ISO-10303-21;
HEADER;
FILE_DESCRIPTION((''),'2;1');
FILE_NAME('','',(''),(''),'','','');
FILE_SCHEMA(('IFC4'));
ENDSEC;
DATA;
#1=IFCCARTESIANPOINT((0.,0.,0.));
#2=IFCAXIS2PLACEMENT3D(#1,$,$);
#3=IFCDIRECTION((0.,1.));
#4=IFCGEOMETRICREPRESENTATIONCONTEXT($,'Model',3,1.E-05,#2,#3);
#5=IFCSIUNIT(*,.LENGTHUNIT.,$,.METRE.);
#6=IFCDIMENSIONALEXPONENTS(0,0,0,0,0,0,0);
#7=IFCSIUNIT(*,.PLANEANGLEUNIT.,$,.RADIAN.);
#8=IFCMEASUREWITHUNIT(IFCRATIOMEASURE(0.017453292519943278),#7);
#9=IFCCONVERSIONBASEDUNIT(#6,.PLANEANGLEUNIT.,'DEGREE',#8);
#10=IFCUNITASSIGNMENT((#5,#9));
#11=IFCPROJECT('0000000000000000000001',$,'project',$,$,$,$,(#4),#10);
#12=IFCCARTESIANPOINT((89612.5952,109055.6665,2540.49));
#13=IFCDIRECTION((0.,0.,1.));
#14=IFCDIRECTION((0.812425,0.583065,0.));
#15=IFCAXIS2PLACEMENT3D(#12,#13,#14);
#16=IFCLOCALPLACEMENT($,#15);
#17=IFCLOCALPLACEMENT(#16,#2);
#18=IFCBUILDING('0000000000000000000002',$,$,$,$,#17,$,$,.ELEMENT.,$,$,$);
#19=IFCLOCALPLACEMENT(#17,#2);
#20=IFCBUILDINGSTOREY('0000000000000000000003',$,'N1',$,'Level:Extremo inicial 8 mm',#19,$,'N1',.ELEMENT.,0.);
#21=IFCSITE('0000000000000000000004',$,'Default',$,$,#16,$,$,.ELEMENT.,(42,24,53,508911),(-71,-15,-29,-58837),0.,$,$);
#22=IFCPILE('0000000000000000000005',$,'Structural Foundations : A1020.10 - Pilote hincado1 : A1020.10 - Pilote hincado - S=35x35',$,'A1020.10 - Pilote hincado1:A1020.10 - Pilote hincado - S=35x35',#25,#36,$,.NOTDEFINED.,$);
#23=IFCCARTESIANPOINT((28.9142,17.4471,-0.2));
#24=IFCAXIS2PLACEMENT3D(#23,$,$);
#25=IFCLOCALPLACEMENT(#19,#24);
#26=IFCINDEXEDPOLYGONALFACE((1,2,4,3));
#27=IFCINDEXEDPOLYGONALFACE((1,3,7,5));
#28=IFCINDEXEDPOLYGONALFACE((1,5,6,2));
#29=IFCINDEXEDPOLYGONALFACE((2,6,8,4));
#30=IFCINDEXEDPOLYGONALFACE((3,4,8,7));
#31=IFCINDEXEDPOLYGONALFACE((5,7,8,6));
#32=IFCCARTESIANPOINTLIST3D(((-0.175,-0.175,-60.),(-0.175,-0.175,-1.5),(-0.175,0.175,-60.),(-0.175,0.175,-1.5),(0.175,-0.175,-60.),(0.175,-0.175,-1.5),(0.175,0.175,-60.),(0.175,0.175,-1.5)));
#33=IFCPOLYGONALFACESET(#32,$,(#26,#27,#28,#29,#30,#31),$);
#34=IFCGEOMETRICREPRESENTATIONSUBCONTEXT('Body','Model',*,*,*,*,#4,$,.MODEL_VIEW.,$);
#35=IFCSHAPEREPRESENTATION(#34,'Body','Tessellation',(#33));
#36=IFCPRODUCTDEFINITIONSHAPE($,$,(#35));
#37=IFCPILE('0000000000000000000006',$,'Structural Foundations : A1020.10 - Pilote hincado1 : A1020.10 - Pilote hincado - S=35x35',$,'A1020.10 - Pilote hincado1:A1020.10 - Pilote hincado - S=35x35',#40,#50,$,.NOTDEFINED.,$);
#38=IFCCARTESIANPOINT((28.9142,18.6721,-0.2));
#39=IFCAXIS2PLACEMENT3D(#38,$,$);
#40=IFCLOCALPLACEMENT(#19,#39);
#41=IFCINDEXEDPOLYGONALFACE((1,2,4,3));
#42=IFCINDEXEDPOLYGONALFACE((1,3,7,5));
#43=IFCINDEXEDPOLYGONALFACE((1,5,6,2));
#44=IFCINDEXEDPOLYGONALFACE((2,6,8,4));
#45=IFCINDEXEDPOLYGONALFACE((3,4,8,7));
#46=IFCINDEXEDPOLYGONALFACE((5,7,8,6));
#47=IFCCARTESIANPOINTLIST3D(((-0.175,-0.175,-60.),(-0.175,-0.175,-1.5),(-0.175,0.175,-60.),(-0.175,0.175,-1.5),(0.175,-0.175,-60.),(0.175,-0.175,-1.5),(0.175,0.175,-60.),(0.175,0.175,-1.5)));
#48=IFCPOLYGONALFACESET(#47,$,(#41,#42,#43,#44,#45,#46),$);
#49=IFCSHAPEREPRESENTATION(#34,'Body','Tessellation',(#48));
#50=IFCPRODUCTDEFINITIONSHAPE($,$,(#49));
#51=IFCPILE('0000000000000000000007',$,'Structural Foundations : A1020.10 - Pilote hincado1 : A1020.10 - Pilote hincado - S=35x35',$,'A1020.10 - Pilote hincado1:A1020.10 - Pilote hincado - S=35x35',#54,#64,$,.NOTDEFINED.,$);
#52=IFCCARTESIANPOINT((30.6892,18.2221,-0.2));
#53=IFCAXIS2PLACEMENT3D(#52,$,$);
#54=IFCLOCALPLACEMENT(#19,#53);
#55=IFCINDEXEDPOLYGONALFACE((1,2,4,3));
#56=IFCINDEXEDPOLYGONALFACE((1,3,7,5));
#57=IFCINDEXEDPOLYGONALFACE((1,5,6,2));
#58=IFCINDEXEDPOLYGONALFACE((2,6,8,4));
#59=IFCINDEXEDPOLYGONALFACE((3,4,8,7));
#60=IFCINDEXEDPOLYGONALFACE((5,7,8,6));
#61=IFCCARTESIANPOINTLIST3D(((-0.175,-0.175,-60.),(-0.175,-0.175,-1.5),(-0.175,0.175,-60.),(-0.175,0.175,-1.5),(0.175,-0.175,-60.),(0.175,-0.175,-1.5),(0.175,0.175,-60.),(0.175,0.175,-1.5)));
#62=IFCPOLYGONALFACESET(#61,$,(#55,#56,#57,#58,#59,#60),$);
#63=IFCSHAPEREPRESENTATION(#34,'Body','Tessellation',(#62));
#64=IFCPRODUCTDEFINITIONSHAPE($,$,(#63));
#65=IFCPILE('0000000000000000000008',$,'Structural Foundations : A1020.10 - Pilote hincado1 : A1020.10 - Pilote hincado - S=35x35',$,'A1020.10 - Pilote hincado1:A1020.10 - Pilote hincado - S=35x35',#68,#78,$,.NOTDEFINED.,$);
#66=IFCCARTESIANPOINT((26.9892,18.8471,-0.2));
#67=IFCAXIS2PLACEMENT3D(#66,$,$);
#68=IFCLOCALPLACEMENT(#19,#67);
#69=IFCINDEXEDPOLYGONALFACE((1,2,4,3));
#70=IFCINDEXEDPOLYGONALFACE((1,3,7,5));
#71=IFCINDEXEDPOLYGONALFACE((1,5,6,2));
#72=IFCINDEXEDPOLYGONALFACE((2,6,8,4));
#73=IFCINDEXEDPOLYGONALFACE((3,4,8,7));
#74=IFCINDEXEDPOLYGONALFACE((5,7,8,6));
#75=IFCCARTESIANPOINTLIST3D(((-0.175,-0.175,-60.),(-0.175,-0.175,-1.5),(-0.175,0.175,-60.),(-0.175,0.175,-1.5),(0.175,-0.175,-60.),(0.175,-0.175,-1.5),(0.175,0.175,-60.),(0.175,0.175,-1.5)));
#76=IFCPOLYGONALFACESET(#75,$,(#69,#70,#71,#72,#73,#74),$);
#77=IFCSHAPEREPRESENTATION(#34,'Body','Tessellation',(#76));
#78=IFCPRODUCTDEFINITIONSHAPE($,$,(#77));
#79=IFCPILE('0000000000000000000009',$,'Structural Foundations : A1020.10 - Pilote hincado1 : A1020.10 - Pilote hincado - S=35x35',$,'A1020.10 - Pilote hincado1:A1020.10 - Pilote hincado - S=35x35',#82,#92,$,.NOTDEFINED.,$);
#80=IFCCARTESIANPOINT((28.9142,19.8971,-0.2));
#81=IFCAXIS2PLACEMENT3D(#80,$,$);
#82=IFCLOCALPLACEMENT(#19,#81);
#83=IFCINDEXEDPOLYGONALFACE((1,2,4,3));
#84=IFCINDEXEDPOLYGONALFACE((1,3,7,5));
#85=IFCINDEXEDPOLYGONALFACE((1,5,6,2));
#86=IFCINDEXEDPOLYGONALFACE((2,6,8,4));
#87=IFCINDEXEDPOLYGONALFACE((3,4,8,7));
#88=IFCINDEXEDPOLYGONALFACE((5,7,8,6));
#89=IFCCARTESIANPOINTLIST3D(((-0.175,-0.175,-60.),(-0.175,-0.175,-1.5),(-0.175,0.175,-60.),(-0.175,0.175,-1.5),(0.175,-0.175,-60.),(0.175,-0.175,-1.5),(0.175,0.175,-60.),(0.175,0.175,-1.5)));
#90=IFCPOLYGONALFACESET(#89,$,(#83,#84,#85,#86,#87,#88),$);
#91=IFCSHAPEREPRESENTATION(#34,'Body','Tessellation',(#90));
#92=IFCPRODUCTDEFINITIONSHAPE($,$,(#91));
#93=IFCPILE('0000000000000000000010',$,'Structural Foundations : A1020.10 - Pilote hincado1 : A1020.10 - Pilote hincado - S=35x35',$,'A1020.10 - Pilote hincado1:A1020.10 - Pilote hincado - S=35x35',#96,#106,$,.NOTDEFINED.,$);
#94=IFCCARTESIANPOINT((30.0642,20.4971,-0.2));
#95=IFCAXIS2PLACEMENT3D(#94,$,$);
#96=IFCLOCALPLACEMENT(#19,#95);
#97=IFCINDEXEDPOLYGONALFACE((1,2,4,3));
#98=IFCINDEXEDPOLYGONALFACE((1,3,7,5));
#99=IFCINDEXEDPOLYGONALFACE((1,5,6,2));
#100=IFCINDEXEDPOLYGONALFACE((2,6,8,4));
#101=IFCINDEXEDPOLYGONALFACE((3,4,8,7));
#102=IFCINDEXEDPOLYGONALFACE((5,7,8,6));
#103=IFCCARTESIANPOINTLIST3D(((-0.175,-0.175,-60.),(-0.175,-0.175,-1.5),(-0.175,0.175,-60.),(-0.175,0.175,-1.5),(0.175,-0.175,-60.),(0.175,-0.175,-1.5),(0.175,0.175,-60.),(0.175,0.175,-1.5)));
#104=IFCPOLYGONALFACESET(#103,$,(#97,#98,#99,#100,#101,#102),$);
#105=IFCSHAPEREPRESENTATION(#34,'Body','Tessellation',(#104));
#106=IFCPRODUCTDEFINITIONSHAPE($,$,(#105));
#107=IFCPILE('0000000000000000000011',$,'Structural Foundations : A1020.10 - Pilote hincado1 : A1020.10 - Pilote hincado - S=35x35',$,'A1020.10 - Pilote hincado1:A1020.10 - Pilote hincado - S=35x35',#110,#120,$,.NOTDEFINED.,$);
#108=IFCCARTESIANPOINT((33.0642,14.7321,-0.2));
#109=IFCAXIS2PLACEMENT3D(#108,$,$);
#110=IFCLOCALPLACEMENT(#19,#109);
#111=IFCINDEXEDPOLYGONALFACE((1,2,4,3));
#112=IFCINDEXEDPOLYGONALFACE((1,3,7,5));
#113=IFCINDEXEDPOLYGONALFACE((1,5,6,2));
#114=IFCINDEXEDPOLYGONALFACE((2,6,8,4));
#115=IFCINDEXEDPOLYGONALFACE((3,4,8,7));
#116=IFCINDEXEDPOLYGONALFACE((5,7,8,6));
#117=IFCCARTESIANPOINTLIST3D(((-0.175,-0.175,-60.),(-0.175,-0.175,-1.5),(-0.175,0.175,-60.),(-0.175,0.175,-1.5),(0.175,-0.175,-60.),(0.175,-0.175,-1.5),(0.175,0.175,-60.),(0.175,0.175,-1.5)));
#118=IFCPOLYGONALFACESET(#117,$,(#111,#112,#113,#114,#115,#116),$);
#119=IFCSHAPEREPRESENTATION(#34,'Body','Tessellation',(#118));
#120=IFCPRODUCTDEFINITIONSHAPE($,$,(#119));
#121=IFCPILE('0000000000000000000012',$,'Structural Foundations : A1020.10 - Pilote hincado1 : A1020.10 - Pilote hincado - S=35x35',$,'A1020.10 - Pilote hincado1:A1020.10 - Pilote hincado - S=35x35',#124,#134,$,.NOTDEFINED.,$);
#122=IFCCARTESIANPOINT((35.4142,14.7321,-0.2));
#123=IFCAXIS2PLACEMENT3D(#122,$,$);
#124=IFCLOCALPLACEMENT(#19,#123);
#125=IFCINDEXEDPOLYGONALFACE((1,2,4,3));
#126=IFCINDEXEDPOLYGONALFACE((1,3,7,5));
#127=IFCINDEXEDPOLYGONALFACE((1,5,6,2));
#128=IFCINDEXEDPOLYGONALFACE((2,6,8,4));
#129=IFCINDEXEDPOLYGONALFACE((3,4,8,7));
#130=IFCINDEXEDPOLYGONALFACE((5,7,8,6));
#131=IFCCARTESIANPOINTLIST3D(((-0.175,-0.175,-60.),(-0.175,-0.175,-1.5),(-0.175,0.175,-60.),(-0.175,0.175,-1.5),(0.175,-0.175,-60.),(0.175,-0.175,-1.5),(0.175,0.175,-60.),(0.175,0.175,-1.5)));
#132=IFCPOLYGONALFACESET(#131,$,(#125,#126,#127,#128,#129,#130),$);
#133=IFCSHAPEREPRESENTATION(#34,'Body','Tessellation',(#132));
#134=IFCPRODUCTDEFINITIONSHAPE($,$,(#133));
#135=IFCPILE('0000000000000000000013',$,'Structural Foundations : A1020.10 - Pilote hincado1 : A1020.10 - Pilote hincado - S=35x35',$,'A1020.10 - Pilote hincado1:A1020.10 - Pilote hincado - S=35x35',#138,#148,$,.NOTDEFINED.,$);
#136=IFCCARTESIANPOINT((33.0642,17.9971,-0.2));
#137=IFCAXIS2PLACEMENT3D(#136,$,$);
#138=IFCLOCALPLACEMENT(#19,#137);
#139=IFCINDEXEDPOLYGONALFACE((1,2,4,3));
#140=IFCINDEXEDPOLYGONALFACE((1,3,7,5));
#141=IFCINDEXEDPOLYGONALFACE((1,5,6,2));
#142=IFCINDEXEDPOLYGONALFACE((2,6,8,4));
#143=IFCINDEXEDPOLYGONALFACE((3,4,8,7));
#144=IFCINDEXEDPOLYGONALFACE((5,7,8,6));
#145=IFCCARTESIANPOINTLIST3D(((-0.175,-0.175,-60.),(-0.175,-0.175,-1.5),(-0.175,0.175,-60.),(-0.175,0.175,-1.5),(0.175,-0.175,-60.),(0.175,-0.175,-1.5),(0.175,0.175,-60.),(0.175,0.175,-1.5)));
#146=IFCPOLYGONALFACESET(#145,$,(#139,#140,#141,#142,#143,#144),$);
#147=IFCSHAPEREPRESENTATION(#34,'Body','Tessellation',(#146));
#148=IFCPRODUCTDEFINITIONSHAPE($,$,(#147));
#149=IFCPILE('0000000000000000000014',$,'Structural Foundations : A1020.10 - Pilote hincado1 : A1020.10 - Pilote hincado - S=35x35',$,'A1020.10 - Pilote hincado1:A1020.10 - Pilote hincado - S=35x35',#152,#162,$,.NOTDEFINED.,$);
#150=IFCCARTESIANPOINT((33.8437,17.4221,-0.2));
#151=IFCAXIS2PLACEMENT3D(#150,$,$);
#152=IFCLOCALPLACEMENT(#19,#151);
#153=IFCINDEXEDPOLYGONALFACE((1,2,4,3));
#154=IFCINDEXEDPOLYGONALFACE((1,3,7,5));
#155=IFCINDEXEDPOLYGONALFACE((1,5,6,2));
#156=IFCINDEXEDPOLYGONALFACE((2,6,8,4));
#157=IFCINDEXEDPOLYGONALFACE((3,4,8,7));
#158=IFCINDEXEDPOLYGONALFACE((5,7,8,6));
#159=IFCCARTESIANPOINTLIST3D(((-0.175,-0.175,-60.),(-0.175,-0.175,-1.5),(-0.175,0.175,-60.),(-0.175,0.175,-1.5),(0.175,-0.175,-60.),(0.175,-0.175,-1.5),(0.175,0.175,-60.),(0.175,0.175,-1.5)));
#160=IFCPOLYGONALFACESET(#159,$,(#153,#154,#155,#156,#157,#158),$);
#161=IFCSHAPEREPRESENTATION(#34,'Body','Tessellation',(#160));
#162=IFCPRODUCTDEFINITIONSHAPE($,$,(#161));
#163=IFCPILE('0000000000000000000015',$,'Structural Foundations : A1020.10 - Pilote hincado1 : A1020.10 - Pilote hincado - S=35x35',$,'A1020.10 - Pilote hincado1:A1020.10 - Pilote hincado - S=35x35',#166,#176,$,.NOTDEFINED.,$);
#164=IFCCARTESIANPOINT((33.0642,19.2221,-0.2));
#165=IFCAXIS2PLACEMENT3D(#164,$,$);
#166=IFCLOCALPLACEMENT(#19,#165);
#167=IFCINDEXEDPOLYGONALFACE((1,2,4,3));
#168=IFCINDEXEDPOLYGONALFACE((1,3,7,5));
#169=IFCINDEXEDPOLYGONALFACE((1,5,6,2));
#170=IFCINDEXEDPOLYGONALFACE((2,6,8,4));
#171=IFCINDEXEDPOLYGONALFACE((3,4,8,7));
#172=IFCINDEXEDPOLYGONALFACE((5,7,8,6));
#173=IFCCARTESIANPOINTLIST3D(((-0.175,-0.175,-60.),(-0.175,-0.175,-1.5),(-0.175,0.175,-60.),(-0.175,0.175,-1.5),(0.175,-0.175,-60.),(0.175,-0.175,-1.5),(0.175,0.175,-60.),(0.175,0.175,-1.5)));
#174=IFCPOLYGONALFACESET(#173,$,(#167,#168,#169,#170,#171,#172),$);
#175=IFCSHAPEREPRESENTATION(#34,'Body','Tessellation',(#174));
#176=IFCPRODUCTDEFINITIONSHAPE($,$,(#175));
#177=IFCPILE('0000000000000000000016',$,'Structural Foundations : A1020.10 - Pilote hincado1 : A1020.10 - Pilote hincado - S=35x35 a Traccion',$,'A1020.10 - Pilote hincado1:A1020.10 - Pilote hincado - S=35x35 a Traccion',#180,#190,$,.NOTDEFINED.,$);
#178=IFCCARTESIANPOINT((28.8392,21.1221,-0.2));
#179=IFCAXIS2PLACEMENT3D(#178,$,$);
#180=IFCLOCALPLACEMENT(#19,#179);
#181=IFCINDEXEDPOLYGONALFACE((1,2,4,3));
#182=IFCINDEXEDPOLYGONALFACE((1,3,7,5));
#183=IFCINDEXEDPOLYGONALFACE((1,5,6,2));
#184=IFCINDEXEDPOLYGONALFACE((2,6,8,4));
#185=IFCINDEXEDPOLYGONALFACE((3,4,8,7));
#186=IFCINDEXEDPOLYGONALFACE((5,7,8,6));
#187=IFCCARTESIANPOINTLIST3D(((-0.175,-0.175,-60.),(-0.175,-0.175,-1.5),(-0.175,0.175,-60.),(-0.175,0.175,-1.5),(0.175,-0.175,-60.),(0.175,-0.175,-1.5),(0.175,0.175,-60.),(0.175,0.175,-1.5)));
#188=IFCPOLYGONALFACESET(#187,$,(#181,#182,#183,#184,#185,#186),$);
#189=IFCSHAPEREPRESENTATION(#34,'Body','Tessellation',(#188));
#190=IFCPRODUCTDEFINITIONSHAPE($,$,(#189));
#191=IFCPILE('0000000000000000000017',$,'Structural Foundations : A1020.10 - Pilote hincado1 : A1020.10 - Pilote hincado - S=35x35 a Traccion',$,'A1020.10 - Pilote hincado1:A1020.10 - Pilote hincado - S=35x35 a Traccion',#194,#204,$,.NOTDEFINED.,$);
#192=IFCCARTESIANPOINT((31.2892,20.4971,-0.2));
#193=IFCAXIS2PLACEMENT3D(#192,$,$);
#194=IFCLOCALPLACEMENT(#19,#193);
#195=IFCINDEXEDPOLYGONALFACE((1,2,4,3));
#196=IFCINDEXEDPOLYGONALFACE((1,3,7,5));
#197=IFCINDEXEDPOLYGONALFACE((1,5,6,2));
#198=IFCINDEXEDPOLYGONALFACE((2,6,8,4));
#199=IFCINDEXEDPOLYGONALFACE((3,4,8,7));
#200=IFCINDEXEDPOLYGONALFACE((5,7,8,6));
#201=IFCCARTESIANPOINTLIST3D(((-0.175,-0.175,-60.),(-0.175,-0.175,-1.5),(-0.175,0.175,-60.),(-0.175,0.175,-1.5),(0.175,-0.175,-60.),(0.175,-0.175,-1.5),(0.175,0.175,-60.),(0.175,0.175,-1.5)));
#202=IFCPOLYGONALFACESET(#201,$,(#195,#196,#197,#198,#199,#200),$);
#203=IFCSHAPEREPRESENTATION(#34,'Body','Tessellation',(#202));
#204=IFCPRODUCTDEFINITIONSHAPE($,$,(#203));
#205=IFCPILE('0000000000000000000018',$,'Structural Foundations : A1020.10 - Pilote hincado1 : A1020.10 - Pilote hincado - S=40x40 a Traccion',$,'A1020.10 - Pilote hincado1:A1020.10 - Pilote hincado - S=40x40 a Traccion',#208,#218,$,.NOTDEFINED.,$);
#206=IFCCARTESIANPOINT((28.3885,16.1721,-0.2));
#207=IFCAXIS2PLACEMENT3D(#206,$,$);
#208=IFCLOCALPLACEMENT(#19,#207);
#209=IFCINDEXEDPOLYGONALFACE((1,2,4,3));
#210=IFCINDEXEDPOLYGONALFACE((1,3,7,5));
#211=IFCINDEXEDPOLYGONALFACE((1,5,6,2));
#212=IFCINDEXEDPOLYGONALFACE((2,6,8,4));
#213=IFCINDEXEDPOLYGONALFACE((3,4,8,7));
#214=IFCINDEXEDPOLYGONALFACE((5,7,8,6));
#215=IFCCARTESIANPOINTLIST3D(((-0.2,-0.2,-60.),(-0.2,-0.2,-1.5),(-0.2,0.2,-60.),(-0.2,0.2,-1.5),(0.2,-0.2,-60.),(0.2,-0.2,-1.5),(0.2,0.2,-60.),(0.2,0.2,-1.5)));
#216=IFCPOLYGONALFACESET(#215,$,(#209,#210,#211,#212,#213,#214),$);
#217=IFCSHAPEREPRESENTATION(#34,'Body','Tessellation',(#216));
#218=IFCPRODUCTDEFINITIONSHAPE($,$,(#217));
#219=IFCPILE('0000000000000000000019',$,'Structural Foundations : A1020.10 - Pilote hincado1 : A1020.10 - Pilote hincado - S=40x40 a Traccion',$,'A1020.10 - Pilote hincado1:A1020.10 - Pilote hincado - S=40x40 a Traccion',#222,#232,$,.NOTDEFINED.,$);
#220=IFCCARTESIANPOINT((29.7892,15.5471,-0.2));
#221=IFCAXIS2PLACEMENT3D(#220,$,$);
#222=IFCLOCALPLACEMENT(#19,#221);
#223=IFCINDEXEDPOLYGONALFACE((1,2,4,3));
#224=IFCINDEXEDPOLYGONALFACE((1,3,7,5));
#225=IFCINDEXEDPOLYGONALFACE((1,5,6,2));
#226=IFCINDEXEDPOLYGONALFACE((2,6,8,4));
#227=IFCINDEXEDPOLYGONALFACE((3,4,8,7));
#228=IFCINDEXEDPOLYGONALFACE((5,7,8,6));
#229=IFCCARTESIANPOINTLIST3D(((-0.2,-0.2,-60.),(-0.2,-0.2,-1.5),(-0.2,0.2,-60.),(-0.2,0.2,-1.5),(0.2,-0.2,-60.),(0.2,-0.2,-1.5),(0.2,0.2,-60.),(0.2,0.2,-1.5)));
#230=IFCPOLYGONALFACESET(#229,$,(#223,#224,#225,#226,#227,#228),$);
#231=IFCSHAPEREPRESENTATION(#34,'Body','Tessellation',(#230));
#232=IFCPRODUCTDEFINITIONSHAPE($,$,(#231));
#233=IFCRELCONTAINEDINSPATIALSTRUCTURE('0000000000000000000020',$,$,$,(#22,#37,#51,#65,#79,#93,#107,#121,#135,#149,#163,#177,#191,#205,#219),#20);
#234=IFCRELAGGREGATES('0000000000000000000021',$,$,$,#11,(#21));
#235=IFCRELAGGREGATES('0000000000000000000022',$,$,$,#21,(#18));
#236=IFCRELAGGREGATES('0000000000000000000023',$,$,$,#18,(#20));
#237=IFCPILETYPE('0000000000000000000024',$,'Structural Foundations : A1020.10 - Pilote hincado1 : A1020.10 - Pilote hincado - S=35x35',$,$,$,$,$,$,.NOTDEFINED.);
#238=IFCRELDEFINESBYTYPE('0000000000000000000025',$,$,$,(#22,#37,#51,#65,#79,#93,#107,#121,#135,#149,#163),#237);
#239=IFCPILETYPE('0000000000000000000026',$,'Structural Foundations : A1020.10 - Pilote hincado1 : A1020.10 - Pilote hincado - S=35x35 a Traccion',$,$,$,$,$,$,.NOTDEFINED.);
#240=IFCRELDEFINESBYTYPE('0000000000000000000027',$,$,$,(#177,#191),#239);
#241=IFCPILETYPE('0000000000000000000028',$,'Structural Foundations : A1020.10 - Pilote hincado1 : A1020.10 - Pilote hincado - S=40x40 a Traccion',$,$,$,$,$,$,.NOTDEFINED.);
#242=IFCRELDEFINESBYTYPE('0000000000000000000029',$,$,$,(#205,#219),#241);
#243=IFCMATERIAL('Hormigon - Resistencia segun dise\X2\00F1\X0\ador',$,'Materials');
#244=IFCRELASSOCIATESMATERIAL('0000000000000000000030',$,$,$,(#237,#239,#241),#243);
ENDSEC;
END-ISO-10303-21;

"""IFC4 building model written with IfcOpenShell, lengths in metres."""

from ifc_helpers import new_model, entity, si_unit, converted_unit, direction, frame, origin, origin_2d_with_axis, place, context, subcontext, project, spatial, polyline, segment, composite_curve, rectangle, outline, extrude, source, transform, mapped, material, material_profile, profile_set, type_object, type_shapes, element, save


model = new_model("IFC4")

# Units and contexts
model_context = context("Model", 3, precision=1e-05, world=origin(), true_north=direction((0.0, 1.0)))
body_context = subcontext(model_context, "Body", "Model", "MODEL_VIEW")
ifc_project = project(units=[si_unit("LENGTHUNIT", "METRE"), converted_unit("PLANEANGLEUNIT", "DEGREE", entity("IfcRatioMeasure", 0.017453292519943278), si_unit("PLANEANGLEUNIT", "RADIAN"), dimensions=[0, 0, 0, 0, 0, 0, 0])], contexts=[model_context])

# Site, building, storey
site_placement = place(None, frame((89612.5952, 109055.6665, 2540.49), z_axis=(0.0, 0.0, 1.0), x_axis=(0.812425, 0.583065, 0.0)))
site = spatial("IfcSite", under=ifc_project, at=site_placement, Name="Default", CompositionType="ELEMENT", RefLatitude=(42, 24, 53, 508911), RefLongitude=(-71, -15, -29, -58837), RefElevation=0.0)
building_placement = place(site_placement, origin())
building = spatial("IfcBuilding", under=site, at=building_placement, CompositionType="ELEMENT")
storey_placement = place(building_placement, origin())
storey = spatial("IfcBuildingStorey", under=building, at=storey_placement, Name="N1", ObjectType="Level:Extremo inicial 8 mm", LongName="N1", CompositionType="ELEMENT", Elevation=0.0)

# Piles
ifc_material_1 = material(Name="Hormigon - Resistencia segun diseñador", Category="Materials")
ifc_material_profile_1 = material_profile(ifc_material_1, outline(composite_curve([segment(polyline([(0.175, 0.175, -60.0), (0.175, -0.175, -60.0)]), True, "CONTINUOUS"), segment(polyline([(0.175, -0.175, -60.0), (-0.175, -0.175, -60.0)]), True, "CONTINUOUS"), segment(polyline([(-0.175, -0.175, -60.0), (-0.175, 0.175, -60.0)]), True, "CONTINUOUS"), segment(polyline([(-0.175, 0.175, -60.0), (0.175, 0.175, -60.0)]), True, "CONTINUOUS")], self_intersect=False), kind="CURVE"), Name="A1020.10 - Pilote hincado - S=35x35")
ifc_profile_set_1 = profile_set([ifc_material_profile_1], Name="A1020.10 - Pilote hincado - S=35x35")
pile_type_1 = type_object("IfcPileType", Name="Structural Foundations : A1020.10 - Pilote hincado1 : A1020.10 - Pilote hincado - S=35x35", PredefinedType="NOTDEFINED", material=ifc_profile_set_1)
shared_shape_1 = source(origin(), body_context, "Body", "SweptSolid", [
    extrude(rectangle(XDim=0.35, YDim=0.35, at=origin_2d_with_axis()), frame((0.0, 0.0, -60.0), z_axis=(0.0, 0.0, 1.0), x_axis=(0.0, -1.0, 0.0)), (0.0, 0.0, 1.0), 58.5),
])
type_shapes(pile_type_1, [shared_shape_1])
for number, where, name in (
    (1, (28.9142, 17.4471, -0.2), "Structural Foundations : A1020.10 - Pilote hincado1 : A1020.10 - Pilote hincado - S=35x35"),
    (2, (28.9142, 18.6721, -0.2), "Structural Foundations : A1020.10 - Pilote hincado1 : A1020.10 - Pilote hincado - S=35x35"),
    (3, (30.6892, 18.2221, -0.2), "Structural Foundations : A1020.10 - Pilote hincado1 : A1020.10 - Pilote hincado - S=35x35"),
    (4, (26.9892, 18.8471, -0.2), "Structural Foundations : A1020.10 - Pilote hincado1 : A1020.10 - Pilote hincado - S=35x35"),
    (5, (28.9142, 19.8971, -0.2), "Structural Foundations : A1020.10 - Pilote hincado1 : A1020.10 - Pilote hincado - S=35x35"),
    (6, (30.0642, 20.4971, -0.2), "Structural Foundations : A1020.10 - Pilote hincado1 : A1020.10 - Pilote hincado - S=35x35"),
    (7, (33.0642, 14.7321, -0.2), "Structural Foundations : A1020.10 - Pilote hincado1 : A1020.10 - Pilote hincado - S=35x35"),
    (8, (35.4142, 14.7321, -0.2), "Structural Foundations : A1020.10 - Pilote hincado1 : A1020.10 - Pilote hincado - S=35x35"),
    (9, (33.0642, 17.9971, -0.2), "Structural Foundations : A1020.10 - Pilote hincado1 : A1020.10 - Pilote hincado - S=35x35"),
    (10, (33.8437, 17.4221, -0.2), "Structural Foundations : A1020.10 - Pilote hincado1 : A1020.10 - Pilote hincado - S=35x35"),
    (11, (33.0642, 19.2221, -0.2), "Structural Foundations : A1020.10 - Pilote hincado1 : A1020.10 - Pilote hincado - S=35x35"),
):
    element("IfcPile", number, at=place(storey_placement, frame(where)), inside=storey, type_object=pile_type_1, Name=name, ObjectType="A1020.10 - Pilote hincado1:A1020.10 - Pilote hincado - S=35x35", PredefinedType="NOTDEFINED", context=body_context, shape_type="MappedRepresentation", body=[
        mapped(shared_shape_1, transform((0.0, 0.0, 0.0), scale=1.0)),
    ])
ifc_material_profile_2 = material_profile(ifc_material_1, outline(composite_curve([segment(polyline([(0.175, 0.175, -60.0), (0.175, -0.175, -60.0)]), True, "CONTINUOUS"), segment(polyline([(0.175, -0.175, -60.0), (-0.175, -0.175, -60.0)]), True, "CONTINUOUS"), segment(polyline([(-0.175, -0.175, -60.0), (-0.175, 0.175, -60.0)]), True, "CONTINUOUS"), segment(polyline([(-0.175, 0.175, -60.0), (0.175, 0.175, -60.0)]), True, "CONTINUOUS")], self_intersect=False), kind="CURVE"), Name="A1020.10 - Pilote hincado - S=35x35 a Traccion")
ifc_profile_set_2 = profile_set([ifc_material_profile_2], Name="A1020.10 - Pilote hincado - S=35x35 a Traccion")
pile_type_2 = type_object("IfcPileType", Name="Structural Foundations : A1020.10 - Pilote hincado1 : A1020.10 - Pilote hincado - S=35x35 a Traccion", PredefinedType="NOTDEFINED", material=ifc_profile_set_2)
shared_shape_2 = source(origin(), body_context, "Body", "SweptSolid", [
    extrude(rectangle(XDim=0.35, YDim=0.35, at=origin_2d_with_axis()), frame((0.0, 0.0, -60.0), z_axis=(0.0, 0.0, 1.0), x_axis=(0.0, -1.0, 0.0)), (0.0, 0.0, 1.0), 58.5),
])
type_shapes(pile_type_2, [shared_shape_2])
for number, where, name in (
    (12, (28.8392, 21.1221, -0.2), "Structural Foundations : A1020.10 - Pilote hincado1 : A1020.10 - Pilote hincado - S=35x35 a Traccion"),
    (13, (31.2892, 20.4971, -0.2), "Structural Foundations : A1020.10 - Pilote hincado1 : A1020.10 - Pilote hincado - S=35x35 a Traccion"),
):
    element("IfcPile", number, at=place(storey_placement, frame(where)), inside=storey, type_object=pile_type_2, Name=name, ObjectType="A1020.10 - Pilote hincado1:A1020.10 - Pilote hincado - S=35x35 a Traccion", PredefinedType="NOTDEFINED", context=body_context, shape_type="MappedRepresentation", body=[
        mapped(shared_shape_2, transform((0.0, 0.0, 0.0), scale=1.0)),
    ])
ifc_material_profile_3 = material_profile(ifc_material_1, outline(composite_curve([segment(polyline([(0.2, 0.2, -60.0), (0.2, -0.2, -60.0)]), True, "CONTINUOUS"), segment(polyline([(0.2, -0.2, -60.0), (-0.2, -0.2, -60.0)]), True, "CONTINUOUS"), segment(polyline([(-0.2, -0.2, -60.0), (-0.2, 0.2, -60.0)]), True, "CONTINUOUS"), segment(polyline([(-0.2, 0.2, -60.0), (0.2, 0.2, -60.0)]), True, "CONTINUOUS")], self_intersect=False), kind="CURVE"), Name="A1020.10 - Pilote hincado - S=40x40 a Traccion")
ifc_profile_set_3 = profile_set([ifc_material_profile_3], Name="A1020.10 - Pilote hincado - S=40x40 a Traccion")
pile_type_3 = type_object("IfcPileType", Name="Structural Foundations : A1020.10 - Pilote hincado1 : A1020.10 - Pilote hincado - S=40x40 a Traccion", PredefinedType="NOTDEFINED", material=ifc_profile_set_3)
shared_shape_3 = source(origin(), body_context, "Body", "SweptSolid", [
    extrude(rectangle(XDim=0.4, YDim=0.4, at=origin_2d_with_axis()), frame((0.0, 0.0, -60.0), z_axis=(0.0, 0.0, 1.0), x_axis=(0.0, -1.0, 0.0)), (0.0, 0.0, 1.0), 58.5),
])
type_shapes(pile_type_3, [shared_shape_3])
for number, where, name in (
    (14, (28.3885, 16.1721, -0.2), "Structural Foundations : A1020.10 - Pilote hincado1 : A1020.10 - Pilote hincado - S=40x40 a Traccion"),
    (15, (29.7892, 15.5471, -0.2), "Structural Foundations : A1020.10 - Pilote hincado1 : A1020.10 - Pilote hincado - S=40x40 a Traccion"),
):
    element("IfcPile", number, at=place(storey_placement, frame(where)), inside=storey, type_object=pile_type_3, Name=name, ObjectType="A1020.10 - Pilote hincado1:A1020.10 - Pilote hincado - S=40x40 a Traccion", PredefinedType="NOTDEFINED", context=body_context, shape_type="MappedRepresentation", body=[
        mapped(shared_shape_3, transform((0.0, 0.0, 0.0), scale=1.0)),
    ])

save(model, "model.ifc")
